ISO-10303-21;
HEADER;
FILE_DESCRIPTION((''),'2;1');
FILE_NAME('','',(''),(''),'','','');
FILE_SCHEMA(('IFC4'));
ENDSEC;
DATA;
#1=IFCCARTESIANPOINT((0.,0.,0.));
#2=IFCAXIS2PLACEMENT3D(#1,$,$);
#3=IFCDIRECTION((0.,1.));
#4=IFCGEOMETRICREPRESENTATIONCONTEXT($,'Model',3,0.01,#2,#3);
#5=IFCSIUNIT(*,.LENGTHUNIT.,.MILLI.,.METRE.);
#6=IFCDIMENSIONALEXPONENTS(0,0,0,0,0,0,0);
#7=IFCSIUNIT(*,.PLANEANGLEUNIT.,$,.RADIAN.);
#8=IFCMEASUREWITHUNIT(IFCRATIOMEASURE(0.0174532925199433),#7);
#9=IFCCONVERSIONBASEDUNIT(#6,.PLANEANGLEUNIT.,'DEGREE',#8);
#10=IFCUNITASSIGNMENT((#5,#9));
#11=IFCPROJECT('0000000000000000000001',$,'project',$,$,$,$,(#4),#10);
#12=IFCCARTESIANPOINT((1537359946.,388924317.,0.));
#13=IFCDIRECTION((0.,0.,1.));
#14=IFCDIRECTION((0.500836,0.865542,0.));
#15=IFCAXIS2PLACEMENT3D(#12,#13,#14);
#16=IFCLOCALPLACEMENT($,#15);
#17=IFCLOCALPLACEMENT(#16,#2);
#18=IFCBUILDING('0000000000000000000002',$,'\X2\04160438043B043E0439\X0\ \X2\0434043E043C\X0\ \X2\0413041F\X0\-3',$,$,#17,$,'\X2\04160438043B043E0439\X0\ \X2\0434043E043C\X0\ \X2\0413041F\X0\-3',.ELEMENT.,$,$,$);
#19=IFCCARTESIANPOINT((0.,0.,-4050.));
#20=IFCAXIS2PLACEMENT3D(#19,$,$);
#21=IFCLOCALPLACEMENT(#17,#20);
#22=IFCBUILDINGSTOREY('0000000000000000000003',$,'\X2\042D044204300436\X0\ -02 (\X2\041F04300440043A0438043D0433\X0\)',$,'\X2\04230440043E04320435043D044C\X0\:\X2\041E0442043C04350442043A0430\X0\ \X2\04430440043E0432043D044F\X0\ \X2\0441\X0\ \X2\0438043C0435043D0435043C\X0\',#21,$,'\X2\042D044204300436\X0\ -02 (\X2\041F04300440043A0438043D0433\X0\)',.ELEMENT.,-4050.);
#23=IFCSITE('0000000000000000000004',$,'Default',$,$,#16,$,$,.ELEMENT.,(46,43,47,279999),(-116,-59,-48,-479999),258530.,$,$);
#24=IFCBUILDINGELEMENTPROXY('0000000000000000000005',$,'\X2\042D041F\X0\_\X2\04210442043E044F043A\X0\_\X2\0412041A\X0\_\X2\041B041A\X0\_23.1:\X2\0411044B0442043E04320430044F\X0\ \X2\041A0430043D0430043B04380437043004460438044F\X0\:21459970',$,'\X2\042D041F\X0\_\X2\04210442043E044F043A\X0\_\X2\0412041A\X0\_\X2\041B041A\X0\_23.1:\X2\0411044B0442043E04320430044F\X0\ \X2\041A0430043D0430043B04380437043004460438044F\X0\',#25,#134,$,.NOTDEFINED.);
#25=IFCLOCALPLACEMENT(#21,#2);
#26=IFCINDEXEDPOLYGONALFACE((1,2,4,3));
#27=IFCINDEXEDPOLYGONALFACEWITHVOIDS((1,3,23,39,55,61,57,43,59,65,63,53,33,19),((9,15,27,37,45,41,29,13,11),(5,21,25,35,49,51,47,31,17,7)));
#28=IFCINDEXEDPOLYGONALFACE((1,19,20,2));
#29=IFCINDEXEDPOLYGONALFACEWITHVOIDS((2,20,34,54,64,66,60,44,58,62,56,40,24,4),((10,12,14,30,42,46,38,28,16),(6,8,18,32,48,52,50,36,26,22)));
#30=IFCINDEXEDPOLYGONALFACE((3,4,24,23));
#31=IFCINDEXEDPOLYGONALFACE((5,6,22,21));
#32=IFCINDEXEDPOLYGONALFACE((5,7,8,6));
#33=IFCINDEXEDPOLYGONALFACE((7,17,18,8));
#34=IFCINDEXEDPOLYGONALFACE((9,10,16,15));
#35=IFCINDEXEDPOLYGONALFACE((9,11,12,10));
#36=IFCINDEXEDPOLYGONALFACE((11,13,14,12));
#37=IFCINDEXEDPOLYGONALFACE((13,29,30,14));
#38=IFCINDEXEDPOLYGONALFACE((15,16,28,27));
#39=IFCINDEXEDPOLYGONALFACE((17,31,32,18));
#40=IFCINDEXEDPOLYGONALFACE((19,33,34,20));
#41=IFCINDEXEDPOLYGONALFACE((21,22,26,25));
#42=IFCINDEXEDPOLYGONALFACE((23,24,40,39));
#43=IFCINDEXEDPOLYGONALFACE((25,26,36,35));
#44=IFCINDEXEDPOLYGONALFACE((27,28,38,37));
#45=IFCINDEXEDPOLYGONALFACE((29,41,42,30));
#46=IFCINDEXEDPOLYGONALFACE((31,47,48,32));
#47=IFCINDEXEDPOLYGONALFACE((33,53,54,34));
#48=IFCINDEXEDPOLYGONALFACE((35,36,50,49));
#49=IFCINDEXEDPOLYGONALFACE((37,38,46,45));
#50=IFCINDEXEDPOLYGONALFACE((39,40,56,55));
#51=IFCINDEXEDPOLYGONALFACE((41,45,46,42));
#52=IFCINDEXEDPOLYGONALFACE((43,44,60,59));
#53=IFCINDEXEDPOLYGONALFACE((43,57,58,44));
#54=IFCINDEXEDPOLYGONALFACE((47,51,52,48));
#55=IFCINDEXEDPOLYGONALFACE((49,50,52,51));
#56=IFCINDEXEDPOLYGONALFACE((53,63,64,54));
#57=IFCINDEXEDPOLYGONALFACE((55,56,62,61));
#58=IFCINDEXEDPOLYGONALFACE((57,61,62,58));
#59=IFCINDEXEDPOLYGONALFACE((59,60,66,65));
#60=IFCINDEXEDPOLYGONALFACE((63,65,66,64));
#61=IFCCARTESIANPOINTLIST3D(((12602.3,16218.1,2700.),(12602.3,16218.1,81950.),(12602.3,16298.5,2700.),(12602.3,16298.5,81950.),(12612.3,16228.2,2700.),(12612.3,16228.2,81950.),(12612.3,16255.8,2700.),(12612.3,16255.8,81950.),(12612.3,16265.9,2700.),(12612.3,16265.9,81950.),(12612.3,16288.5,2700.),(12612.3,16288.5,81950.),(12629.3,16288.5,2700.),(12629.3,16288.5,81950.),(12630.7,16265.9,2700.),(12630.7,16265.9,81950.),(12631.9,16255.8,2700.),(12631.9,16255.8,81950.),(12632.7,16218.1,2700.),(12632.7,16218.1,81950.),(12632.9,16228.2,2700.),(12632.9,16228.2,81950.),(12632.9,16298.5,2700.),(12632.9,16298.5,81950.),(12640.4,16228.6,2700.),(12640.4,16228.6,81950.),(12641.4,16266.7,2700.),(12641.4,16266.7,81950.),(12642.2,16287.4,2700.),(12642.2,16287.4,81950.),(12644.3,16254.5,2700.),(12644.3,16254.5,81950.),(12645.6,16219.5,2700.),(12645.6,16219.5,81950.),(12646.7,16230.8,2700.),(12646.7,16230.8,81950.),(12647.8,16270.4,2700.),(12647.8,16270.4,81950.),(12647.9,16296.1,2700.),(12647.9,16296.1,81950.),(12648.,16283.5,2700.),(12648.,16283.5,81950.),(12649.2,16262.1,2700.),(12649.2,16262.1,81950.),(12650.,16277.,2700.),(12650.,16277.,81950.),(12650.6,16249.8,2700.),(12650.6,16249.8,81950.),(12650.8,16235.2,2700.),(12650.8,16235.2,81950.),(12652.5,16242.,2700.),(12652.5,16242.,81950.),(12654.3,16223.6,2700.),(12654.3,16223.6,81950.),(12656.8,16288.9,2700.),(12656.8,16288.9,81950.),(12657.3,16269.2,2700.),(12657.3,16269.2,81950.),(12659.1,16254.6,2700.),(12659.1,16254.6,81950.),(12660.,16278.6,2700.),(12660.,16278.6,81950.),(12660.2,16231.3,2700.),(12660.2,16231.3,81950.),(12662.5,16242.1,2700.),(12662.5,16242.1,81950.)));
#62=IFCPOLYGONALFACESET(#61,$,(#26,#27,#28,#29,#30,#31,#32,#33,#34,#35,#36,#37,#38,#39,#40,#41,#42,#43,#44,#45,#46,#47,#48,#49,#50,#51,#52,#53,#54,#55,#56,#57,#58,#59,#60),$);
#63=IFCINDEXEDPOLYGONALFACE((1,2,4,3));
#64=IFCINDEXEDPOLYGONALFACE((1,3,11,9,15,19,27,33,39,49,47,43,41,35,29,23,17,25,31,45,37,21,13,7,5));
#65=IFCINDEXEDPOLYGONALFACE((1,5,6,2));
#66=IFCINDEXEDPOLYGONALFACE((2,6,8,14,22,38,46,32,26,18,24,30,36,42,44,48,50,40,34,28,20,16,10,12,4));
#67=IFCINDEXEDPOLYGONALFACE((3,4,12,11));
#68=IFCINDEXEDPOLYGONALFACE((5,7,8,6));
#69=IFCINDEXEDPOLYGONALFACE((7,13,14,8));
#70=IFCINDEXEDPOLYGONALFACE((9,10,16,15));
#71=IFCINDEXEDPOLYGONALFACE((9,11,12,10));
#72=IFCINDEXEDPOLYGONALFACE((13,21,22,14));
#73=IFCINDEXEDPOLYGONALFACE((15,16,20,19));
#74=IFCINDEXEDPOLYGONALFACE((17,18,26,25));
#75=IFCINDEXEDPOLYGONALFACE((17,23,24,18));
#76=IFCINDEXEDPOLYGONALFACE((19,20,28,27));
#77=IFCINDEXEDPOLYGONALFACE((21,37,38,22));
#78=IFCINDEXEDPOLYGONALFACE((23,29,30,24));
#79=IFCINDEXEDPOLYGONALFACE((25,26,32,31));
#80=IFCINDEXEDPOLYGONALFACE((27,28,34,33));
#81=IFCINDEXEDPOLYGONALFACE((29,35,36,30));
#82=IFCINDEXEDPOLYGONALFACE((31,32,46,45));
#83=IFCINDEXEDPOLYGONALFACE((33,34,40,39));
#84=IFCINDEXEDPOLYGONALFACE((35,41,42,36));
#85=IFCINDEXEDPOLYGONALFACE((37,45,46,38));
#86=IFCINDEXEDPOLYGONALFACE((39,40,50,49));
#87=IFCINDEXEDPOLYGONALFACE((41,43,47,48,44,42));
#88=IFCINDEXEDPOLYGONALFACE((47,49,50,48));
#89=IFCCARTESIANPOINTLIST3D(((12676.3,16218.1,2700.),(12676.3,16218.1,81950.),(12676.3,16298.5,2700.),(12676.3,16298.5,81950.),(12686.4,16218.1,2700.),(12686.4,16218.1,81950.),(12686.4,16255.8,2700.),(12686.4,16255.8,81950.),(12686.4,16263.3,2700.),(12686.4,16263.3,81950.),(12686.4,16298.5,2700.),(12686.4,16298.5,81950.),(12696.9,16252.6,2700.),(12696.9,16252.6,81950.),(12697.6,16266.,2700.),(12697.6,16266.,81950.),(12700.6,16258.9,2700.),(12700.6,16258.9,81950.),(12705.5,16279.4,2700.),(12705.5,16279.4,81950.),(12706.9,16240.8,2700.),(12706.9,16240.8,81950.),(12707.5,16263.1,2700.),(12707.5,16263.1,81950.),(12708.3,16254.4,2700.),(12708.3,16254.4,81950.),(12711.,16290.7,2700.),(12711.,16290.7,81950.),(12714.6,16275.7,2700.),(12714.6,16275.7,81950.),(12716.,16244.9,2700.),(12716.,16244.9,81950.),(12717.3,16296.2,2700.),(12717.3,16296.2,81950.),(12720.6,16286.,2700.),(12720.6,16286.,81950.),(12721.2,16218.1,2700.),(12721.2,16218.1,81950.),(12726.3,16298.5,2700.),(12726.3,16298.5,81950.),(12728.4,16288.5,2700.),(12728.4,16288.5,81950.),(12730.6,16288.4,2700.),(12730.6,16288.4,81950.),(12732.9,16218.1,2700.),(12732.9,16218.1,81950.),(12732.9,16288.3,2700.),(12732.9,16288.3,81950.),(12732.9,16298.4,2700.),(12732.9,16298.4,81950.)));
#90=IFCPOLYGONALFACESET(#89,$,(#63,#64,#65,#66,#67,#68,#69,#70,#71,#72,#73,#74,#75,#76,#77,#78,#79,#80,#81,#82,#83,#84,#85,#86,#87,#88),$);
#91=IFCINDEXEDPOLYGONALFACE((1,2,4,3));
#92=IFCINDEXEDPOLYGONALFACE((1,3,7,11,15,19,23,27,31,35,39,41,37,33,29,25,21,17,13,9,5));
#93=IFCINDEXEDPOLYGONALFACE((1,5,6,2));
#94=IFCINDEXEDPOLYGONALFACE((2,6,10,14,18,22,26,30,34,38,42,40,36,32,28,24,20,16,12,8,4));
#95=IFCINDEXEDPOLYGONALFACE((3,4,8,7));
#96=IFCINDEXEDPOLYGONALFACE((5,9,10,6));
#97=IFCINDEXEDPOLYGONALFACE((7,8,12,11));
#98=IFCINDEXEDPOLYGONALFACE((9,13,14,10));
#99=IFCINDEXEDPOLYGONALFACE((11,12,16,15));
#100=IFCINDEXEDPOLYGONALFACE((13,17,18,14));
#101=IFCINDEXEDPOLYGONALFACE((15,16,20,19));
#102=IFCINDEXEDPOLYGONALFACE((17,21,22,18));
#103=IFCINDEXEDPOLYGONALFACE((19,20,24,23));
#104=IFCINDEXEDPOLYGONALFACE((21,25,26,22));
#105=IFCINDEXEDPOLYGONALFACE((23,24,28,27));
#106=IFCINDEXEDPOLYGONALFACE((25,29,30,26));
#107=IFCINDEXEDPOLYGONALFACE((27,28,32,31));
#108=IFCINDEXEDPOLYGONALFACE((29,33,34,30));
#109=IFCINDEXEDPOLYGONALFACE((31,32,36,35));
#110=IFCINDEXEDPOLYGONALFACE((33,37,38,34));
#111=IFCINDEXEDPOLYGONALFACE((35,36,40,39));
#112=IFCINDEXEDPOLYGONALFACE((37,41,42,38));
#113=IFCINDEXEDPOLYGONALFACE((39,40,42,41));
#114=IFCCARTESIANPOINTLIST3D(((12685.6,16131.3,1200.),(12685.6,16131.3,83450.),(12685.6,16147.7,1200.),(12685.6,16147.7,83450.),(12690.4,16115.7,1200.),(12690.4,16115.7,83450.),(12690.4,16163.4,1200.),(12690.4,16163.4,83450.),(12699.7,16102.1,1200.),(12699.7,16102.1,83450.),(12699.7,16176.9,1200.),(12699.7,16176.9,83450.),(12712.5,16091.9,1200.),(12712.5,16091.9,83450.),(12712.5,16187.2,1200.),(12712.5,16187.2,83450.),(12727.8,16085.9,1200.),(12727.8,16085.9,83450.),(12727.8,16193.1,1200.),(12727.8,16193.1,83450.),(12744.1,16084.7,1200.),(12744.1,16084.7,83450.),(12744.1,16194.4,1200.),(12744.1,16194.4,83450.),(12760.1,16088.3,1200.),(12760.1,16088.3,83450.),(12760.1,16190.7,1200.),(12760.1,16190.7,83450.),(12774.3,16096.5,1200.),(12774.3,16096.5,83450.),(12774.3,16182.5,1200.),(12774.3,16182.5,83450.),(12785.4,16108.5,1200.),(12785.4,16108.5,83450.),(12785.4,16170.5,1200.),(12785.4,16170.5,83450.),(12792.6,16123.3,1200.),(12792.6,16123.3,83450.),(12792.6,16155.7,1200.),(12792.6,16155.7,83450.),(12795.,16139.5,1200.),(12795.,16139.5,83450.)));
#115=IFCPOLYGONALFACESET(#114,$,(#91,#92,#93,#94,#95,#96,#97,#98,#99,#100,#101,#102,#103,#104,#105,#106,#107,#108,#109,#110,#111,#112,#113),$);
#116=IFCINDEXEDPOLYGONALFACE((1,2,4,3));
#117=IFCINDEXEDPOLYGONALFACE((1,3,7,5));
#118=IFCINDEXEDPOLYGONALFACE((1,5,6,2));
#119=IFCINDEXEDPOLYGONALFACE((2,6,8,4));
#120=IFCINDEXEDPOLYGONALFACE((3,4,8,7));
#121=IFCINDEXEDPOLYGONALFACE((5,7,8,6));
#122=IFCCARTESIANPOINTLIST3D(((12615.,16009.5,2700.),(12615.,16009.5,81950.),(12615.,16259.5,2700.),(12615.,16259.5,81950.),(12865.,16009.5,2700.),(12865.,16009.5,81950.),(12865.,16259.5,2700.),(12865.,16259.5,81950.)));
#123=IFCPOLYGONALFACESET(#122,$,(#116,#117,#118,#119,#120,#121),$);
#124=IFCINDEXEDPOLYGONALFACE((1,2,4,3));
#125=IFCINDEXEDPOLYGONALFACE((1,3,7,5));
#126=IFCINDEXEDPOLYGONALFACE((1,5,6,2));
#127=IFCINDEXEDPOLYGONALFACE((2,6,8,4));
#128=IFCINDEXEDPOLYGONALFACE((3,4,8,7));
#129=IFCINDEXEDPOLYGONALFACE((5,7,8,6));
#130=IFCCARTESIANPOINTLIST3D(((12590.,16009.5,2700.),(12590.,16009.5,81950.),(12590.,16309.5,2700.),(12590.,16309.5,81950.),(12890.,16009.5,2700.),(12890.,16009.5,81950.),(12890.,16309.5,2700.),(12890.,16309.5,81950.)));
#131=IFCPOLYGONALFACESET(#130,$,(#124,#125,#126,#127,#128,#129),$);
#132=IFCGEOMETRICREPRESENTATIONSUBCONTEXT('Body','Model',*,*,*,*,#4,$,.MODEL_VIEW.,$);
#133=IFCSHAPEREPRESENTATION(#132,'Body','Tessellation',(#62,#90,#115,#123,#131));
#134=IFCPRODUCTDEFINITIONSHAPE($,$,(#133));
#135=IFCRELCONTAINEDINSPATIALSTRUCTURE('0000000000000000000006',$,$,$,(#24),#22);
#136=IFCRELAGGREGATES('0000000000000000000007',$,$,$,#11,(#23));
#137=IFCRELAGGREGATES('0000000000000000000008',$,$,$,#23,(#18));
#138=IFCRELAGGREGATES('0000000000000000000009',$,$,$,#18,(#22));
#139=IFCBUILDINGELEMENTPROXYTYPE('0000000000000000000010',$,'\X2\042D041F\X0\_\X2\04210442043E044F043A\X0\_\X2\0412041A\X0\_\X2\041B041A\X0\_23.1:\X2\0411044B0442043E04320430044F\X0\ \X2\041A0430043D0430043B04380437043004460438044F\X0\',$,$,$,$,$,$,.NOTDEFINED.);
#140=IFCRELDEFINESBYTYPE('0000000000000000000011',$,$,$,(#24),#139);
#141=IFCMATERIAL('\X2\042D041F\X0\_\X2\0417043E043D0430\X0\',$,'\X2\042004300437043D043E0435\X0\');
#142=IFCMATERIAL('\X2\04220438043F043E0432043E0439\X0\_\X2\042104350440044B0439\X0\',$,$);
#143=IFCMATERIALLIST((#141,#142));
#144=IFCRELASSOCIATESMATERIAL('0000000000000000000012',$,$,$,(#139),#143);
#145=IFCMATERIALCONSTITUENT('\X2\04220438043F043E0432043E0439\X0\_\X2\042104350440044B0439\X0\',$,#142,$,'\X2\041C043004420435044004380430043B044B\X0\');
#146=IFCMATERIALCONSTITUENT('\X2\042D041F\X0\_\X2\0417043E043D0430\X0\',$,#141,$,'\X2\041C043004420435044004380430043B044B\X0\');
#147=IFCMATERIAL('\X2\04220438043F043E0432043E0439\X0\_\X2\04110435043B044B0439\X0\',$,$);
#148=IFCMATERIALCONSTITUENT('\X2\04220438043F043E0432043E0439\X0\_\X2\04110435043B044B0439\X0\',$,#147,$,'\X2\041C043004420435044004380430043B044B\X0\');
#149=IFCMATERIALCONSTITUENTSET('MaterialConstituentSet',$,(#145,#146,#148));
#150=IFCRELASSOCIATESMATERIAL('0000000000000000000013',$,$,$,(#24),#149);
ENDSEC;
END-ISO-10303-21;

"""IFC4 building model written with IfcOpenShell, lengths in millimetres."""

from ifc_helpers import new_model, entity, si_unit, converted_unit, direction, frame, frame_2d, origin, place, context, subcontext, project, spatial, polyline, rectangle, circle, outline, extrude, source, transform, mapped, material, material_list, constituent, constituent_set, type_object, type_shapes, element, save


model = new_model("IFC4")

# Units and contexts
model_context = context("Model", 3, precision=0.01, world=origin(), true_north=direction((0.0, 1.0)))
body_context = subcontext(model_context, "Body", "Model", "MODEL_VIEW")
ifc_project = project(units=[si_unit("LENGTHUNIT", "METRE", prefix="MILLI"), converted_unit("PLANEANGLEUNIT", "DEGREE", entity("IfcRatioMeasure", 0.0174532925199433), si_unit("PLANEANGLEUNIT", "RADIAN"), dimensions=[0, 0, 0, 0, 0, 0, 0])], contexts=[model_context])

# Site, building, storey
site_placement = place(None, frame((1537359946.0, 388924317.0, 0.0), z_axis=(0.0, 0.0, 1.0), x_axis=(0.500836, 0.865542, 0.0)))
site = spatial("IfcSite", under=ifc_project, at=site_placement, Name="Default", CompositionType="ELEMENT", RefLatitude=(46, 43, 47, 279999), RefLongitude=(-116, -59, -48, -479999), RefElevation=258530.0)
building_placement = place(site_placement, origin())
building = spatial("IfcBuilding", under=site, at=building_placement, Name="Жилой дом ГП-3", LongName="Жилой дом ГП-3", CompositionType="ELEMENT")
storey_placement = place(building_placement, frame((0.0, 0.0, -4050.0)))
storey = spatial("IfcBuildingStorey", under=building, at=storey_placement, Name="Этаж -02 (Паркинг)", ObjectType="Уровень:Отметка уровня с именем", LongName="Этаж -02 (Паркинг)", CompositionType="ELEMENT", Elevation=-4050.0)

# Building element proxy
ifc_material_1 = material(Name="ЭП_Зона", Category="Разное")
ifc_material_2 = material(Name="Типовой_Белый")
ifc_material_3 = material(Name="Типовой_Серый")
ifc_constituent_1 = constituent(ifc_material_3, Name="Типовой_Серый", Category="Материалы")
ifc_constituent_2 = constituent(ifc_material_1, Name="ЭП_Зона", Category="Материалы")
ifc_constituent_3 = constituent(ifc_material_2, Name="Типовой_Белый", Category="Материалы")
ifc_constituent_set_1 = constituent_set(constituents=[ifc_constituent_1, ifc_constituent_2, ifc_constituent_3], Name="MaterialConstituentSet")
ifc_material_list_1 = material_list([ifc_material_1, ifc_material_3])
building_element_proxy_type_1 = type_object("IfcBuildingElementProxyType", Name="ЭП_Стояк_ВК_ЛК_23.1:Бытовая Канализация", PredefinedType="NOTDEFINED", material=ifc_material_list_1)
shared_shape_1 = source(origin(), body_context, "Body", "SweptSolid", [
    extrude(outline(polyline([(-42.2, -39.0), (-11.8, -39.0), (1.1, -37.6), (9.8, -33.5), (15.7, -25.8), (18.0, -15.0), (14.6, -2.5), (4.7, 5.0), (12.8, 12.1), (15.5, 21.5), (12.3, 31.8), (3.4, 39.0), (-11.6, 41.4), (-42.2, 41.4), (-42.2, -39.0)]), holes=[polyline([(-32.2, 8.8), (-32.2, 31.4), (-15.2, 31.4), (-2.3, 30.3), (3.5, 26.4), (5.5, 19.9), (3.3, 13.3), (-3.1, 9.6), (-13.9, 8.8), (-32.2, 8.8)]), polyline([(-32.2, -28.9), (-32.2, -1.3), (-12.6, -1.3), (-0.2, -2.6), (6.1, -7.3), (8.0, -15.1), (6.3, -21.9), (2.2, -26.3), (-4.1, -28.5), (-11.6, -28.9), (-32.2, -28.9)])]), frame((54.5, -52.4, -1350.0)), (0.0, 0.0, 1.0), 79250.0),
    extrude(outline(polyline([(-32.1, -31.9), (48.3, -31.9), (48.3, -21.8), (10.6, -21.8), (13.8, -11.4), (25.6, -1.3), (48.3, 13.0), (48.3, 24.6), (21.4, 7.7), (12.0, 0.1), (7.4, -7.7), (3.3, -0.7), (-9.3, 6.4), (-19.7, 12.3), (-22.1, 20.2), (-22.0, 22.4), (-22.0, 24.6), (-32.0, 24.6), (-32.1, 18.0), (-29.9, 9.0), (-24.3, 2.8), (-13.1, -2.8), (0.4, -10.6), (3.0, -21.8), (-32.1, -21.8), (-32.1, -31.9)])), frame((118.2, -43.1, -1350.0), z_axis=(0.0, 0.0, 1.0), x_axis=(0.0, -1.0, 0.0)), (0.0, 0.0, 1.0), 79250.0),
    extrude(circle(Radius=55.0, at=frame_2d((0.0, 0.0), x_axis=(1.0, 0.0))), frame((150.0, -170.0, -2850.0)), (0.0, 0.0, 1.0), 82250.0),
    extrude(rectangle(XDim=250.0, YDim=250.0, at=frame_2d((0.0, 0.0), x_axis=(1.0, 0.0))), frame((150.0, -175.0, -1350.0)), (0.0, 0.0, 1.0), 79250.0),
    extrude(rectangle(XDim=300.0, YDim=300.0, at=frame_2d((0.0, 0.0), x_axis=(1.0, 0.0))), frame((150.0, -150.0, -1350.0)), (0.0, 0.0, 1.0), 79250.0),
])
type_shapes(building_element_proxy_type_1, [shared_shape_1])
proxy_1_placement = place(storey_placement, frame((12590.0, 16309.5, 4050.0)))
element("IfcBuildingElementProxy", 1, at=proxy_1_placement, inside=storey, type_object=building_element_proxy_type_1, material=ifc_constituent_set_1, Name="ЭП_Стояк_ВК_ЛК_23.1:Бытовая Канализация:21459970", ObjectType="ЭП_Стояк_ВК_ЛК_23.1:Бытовая Канализация", PredefinedType="NOTDEFINED", context=body_context, shape_type="MappedRepresentation", body=[
    mapped(shared_shape_1, transform((0.0, 0.0, 0.0), scale=1.0)),
])

save(model, "model.ifc")
